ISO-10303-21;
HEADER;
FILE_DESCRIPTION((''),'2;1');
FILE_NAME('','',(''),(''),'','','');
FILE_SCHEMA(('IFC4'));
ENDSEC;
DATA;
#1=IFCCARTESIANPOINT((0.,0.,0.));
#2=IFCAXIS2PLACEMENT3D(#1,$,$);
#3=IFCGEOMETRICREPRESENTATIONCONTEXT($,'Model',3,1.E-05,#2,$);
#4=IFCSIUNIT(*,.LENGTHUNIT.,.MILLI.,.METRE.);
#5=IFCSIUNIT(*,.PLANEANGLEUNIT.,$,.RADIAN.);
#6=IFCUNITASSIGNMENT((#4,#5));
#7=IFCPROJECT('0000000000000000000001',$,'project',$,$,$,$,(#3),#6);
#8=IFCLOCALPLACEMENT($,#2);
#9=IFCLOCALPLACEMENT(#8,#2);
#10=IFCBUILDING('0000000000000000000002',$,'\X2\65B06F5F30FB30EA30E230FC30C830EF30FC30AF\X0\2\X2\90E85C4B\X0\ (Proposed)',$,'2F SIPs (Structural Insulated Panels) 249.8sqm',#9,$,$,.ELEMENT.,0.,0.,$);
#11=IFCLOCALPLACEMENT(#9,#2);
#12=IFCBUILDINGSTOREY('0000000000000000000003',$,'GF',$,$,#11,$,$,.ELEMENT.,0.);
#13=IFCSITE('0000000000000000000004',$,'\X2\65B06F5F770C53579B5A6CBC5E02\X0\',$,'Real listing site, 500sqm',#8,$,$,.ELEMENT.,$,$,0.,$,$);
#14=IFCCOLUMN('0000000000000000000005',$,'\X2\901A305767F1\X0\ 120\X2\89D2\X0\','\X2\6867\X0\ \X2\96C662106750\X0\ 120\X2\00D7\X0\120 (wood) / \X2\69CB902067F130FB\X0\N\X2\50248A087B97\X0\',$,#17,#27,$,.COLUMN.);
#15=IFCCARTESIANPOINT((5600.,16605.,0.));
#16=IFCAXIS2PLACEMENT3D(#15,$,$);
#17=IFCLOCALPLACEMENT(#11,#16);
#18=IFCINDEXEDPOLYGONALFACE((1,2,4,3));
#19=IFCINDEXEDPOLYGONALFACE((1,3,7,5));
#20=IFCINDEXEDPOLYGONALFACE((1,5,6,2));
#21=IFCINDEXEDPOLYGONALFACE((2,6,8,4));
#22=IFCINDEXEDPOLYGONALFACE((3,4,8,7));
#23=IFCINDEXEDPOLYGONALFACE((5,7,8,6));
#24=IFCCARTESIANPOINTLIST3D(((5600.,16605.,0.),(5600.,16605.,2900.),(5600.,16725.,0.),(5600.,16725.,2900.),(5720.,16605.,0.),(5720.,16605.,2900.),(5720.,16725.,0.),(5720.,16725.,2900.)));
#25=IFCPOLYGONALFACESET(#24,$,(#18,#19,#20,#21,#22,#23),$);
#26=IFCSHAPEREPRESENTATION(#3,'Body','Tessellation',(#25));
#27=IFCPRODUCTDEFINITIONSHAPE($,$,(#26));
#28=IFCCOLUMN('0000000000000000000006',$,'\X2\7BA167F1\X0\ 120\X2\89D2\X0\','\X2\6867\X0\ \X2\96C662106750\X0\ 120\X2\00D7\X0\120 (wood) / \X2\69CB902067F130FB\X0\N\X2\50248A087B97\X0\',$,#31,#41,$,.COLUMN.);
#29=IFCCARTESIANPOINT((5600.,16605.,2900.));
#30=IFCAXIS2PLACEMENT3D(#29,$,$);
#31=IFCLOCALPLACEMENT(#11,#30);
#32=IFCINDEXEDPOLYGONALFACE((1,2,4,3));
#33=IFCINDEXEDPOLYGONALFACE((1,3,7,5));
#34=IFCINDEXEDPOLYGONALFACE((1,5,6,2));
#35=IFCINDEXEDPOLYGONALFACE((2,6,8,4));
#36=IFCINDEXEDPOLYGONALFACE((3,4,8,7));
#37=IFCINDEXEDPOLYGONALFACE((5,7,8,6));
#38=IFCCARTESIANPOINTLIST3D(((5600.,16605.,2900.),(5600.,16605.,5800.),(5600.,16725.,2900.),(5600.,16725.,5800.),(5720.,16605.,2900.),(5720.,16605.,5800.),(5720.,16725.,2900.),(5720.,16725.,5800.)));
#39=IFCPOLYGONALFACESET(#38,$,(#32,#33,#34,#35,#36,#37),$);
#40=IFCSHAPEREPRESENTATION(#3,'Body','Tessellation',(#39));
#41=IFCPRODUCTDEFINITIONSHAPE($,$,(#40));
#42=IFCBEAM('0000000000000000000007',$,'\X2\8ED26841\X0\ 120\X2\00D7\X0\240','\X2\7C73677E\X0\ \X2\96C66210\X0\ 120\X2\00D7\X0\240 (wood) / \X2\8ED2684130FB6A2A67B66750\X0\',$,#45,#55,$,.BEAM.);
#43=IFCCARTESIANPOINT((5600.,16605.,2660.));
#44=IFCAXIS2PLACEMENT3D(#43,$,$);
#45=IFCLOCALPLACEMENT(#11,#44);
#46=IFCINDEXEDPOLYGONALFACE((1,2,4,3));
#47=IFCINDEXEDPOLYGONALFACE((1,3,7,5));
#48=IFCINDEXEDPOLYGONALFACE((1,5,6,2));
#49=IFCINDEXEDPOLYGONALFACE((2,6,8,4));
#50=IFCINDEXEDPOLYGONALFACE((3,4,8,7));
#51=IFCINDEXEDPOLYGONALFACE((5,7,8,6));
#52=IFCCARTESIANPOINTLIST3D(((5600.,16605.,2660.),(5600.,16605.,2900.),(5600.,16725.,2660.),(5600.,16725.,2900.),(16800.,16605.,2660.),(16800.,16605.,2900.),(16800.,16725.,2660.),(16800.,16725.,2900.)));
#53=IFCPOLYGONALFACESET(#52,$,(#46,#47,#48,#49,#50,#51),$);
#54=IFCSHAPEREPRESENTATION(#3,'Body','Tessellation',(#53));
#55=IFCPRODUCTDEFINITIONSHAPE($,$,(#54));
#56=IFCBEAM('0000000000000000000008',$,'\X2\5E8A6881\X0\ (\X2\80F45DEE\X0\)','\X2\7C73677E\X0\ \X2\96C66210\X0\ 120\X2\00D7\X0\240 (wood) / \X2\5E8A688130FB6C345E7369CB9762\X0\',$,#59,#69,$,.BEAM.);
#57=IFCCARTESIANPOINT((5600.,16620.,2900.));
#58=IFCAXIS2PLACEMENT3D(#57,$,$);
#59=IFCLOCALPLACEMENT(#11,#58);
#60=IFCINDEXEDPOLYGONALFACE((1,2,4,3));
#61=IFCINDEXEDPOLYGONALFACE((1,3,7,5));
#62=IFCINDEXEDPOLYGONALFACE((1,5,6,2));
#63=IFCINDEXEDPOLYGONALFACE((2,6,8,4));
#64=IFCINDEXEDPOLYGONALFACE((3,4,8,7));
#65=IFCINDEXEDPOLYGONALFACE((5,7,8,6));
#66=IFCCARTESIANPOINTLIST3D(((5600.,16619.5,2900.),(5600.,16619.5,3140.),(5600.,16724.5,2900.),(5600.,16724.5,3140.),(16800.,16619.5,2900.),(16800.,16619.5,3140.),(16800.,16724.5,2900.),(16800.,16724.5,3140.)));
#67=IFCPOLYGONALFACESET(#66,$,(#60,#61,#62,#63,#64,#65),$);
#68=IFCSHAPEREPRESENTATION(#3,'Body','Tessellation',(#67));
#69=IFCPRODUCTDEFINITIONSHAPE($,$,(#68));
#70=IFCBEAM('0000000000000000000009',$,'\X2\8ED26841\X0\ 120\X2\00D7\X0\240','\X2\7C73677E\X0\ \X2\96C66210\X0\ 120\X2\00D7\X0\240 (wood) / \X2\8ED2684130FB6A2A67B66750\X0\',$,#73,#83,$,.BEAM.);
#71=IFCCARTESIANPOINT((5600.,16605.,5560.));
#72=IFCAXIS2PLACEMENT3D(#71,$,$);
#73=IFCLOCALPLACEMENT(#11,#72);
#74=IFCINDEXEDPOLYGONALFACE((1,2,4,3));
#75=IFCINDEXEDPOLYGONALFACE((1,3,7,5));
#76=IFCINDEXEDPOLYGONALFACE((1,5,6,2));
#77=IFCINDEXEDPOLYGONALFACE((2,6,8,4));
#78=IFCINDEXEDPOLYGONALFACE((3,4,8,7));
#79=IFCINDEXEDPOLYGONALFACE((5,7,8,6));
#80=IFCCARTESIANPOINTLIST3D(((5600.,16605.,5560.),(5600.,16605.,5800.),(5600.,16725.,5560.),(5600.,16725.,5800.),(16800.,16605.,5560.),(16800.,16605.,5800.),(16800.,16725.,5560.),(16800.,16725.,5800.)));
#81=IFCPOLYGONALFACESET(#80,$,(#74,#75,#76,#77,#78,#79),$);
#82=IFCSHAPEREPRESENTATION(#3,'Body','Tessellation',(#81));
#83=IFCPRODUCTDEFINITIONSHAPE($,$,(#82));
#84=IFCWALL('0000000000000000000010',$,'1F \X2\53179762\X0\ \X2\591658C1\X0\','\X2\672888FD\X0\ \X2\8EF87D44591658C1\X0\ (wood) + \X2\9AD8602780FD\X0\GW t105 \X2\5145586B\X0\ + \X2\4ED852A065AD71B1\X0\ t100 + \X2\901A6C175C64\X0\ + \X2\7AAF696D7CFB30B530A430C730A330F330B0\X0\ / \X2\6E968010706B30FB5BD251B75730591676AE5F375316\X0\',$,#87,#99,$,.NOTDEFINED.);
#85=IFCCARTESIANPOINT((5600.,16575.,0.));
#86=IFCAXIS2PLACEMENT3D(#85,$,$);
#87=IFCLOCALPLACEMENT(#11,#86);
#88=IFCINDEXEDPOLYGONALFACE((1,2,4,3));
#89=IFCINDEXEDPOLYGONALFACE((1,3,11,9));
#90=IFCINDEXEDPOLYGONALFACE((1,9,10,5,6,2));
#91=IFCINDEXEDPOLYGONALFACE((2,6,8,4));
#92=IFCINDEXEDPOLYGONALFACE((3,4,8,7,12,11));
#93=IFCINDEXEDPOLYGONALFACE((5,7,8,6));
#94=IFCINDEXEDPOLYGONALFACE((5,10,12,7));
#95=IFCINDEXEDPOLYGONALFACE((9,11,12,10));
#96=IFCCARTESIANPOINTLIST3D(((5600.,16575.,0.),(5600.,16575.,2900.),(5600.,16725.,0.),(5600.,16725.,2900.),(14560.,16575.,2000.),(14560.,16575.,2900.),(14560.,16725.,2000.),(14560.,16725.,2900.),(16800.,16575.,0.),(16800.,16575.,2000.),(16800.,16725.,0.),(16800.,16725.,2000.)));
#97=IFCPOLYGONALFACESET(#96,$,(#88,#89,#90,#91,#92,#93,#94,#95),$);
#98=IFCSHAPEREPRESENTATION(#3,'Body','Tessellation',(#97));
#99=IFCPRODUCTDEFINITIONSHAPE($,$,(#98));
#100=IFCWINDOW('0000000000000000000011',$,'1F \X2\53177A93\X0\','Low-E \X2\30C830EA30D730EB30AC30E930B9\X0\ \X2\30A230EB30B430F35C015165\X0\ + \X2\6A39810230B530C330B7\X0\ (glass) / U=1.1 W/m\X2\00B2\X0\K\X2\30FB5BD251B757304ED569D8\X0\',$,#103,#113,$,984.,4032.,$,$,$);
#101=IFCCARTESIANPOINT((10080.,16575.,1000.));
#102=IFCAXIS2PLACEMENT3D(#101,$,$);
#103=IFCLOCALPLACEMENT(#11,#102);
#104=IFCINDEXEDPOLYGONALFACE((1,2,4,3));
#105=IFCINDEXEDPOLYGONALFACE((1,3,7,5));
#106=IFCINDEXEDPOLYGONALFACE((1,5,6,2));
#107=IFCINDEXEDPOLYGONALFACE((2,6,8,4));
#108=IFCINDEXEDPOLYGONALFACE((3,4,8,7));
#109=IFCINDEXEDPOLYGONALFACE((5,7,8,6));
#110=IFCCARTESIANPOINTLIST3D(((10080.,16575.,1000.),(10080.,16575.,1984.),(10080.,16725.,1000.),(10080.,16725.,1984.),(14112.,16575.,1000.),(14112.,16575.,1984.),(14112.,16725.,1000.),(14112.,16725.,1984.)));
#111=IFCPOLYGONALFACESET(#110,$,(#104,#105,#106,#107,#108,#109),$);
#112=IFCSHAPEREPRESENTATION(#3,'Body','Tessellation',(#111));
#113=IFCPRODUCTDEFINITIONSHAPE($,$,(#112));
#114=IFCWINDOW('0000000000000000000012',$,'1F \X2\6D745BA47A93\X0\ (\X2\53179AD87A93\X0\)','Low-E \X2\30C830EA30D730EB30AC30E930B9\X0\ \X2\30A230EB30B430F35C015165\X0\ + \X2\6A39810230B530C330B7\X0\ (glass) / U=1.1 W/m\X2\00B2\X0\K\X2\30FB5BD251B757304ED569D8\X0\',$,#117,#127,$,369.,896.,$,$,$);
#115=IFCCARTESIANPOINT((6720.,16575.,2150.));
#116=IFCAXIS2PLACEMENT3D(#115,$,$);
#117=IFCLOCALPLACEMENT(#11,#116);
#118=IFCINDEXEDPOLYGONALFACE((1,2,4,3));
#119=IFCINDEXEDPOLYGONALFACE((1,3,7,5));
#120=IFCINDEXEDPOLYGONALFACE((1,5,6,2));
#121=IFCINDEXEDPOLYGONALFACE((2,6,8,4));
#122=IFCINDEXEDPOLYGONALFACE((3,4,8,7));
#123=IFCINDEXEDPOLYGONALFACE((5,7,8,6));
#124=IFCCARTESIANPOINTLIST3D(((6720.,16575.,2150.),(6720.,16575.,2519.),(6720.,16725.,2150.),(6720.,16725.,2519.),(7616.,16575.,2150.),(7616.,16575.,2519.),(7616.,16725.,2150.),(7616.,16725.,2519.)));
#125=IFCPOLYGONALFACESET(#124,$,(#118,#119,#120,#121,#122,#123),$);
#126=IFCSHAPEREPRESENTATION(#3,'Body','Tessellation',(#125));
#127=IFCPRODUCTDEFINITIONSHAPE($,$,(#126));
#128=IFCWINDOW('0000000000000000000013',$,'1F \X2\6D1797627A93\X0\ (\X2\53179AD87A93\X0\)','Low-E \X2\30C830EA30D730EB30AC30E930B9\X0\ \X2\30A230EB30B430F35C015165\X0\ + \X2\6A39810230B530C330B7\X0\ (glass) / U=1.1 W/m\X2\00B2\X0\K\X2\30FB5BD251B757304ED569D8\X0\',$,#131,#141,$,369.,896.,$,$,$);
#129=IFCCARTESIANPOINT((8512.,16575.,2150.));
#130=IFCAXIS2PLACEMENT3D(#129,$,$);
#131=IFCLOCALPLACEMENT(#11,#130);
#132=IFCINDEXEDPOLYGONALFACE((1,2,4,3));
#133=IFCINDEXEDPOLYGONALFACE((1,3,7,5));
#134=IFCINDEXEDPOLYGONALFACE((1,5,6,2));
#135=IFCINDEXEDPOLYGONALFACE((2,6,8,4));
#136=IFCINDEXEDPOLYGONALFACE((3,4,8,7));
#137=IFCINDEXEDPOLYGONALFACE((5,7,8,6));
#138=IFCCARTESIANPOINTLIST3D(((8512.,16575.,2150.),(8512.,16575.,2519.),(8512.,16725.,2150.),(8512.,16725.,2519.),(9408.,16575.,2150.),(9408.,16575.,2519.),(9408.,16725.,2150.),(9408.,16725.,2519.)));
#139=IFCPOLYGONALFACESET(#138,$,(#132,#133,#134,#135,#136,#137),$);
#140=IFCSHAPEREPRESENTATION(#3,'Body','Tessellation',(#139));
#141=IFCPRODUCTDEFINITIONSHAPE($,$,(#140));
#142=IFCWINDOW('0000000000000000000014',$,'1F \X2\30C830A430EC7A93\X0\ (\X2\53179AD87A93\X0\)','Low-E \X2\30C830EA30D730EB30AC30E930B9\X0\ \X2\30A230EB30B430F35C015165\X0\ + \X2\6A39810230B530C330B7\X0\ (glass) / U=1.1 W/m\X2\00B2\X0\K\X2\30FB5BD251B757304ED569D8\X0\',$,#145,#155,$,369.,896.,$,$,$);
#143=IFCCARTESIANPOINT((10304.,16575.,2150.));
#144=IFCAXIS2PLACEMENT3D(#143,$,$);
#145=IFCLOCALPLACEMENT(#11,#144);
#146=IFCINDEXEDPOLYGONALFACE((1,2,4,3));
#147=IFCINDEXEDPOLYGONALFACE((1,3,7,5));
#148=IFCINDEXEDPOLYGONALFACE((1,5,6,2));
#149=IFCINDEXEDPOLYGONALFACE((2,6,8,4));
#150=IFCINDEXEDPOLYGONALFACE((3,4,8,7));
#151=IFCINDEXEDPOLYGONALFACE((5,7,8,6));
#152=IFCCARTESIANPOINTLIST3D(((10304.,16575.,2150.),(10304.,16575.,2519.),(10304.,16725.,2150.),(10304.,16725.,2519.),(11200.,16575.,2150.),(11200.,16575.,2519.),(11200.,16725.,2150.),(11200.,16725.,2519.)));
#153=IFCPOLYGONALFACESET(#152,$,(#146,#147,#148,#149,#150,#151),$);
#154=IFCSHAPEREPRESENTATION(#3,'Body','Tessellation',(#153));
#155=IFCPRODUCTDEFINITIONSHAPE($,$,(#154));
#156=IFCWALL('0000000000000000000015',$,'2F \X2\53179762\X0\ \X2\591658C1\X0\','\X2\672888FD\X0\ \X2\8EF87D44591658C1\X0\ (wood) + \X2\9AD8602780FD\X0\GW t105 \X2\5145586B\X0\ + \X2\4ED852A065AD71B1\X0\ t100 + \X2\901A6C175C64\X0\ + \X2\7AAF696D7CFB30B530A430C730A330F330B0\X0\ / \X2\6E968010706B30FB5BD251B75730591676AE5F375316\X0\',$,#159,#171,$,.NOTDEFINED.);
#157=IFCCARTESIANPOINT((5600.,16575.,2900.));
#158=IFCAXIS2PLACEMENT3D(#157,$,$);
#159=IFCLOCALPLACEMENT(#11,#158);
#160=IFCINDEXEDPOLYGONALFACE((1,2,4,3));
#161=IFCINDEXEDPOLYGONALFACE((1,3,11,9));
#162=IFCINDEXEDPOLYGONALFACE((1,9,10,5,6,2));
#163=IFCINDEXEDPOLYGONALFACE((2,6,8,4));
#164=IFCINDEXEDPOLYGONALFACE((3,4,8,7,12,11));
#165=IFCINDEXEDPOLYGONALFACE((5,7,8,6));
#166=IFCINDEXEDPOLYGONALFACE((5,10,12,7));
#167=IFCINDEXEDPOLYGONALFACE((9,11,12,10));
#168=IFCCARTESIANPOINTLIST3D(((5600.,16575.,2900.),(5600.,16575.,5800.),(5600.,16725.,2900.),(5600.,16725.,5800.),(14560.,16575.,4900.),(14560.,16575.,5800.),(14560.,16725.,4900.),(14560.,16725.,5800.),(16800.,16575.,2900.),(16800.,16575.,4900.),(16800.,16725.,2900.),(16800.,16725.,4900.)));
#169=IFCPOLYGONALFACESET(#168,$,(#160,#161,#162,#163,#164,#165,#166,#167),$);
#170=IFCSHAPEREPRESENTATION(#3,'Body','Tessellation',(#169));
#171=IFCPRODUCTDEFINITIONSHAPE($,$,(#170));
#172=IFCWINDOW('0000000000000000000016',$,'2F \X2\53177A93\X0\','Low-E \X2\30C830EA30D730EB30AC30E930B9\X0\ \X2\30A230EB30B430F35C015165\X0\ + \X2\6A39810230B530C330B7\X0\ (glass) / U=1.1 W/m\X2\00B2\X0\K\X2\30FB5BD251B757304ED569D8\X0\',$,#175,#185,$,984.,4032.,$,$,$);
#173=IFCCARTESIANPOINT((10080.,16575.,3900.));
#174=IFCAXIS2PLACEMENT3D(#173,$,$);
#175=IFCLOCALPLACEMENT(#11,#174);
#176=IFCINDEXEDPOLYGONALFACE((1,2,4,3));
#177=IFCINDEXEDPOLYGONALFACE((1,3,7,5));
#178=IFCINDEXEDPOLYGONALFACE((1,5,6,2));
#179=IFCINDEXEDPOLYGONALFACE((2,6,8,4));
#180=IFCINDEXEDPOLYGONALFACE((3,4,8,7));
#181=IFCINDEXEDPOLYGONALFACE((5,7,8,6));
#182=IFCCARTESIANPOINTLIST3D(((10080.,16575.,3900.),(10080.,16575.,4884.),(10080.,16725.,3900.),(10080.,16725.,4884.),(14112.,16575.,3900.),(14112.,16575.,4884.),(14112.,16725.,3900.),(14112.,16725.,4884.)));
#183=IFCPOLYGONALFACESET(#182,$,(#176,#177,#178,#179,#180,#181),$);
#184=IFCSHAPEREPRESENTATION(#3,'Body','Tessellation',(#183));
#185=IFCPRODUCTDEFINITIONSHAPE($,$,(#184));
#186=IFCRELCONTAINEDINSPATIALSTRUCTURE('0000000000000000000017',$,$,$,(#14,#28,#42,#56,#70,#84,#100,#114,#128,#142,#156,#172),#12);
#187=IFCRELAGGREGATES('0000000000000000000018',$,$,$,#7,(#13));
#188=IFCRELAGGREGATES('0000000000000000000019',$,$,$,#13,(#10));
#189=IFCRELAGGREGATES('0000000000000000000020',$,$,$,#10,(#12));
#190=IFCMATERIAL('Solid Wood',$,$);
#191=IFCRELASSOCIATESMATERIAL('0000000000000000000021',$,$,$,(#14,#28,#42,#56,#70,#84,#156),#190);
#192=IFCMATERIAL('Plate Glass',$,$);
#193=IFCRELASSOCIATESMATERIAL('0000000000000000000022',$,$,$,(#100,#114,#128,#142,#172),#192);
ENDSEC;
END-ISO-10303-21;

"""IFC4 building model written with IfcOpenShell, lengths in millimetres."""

from ifc_helpers import new_model, si_unit, frame, frame_2d, origin, place, context, project, spatial, rectangle, extrude, material, element, fill, save


model = new_model("IFC4")

# Units and contexts
model_context = context("Model", 3, precision=1e-05, world=origin())
ifc_project = project(units=[si_unit("LENGTHUNIT", "METRE", prefix="MILLI"), si_unit("PLANEANGLEUNIT", "RADIAN")], contexts=[model_context])

# Site, building, storey
site_placement = place(None, origin())
site = spatial("IfcSite", under=ifc_project, at=site_placement, Name="新潟県南魚沼市", ObjectType="Real listing site, 500sqm", CompositionType="ELEMENT", RefElevation=0.0)
building_placement = place(site_placement, origin())
building = spatial("IfcBuilding", under=site, at=building_placement, Name="新潟・リモートワーク2部屋 (Proposed)", ObjectType="2F SIPs (Structural Insulated Panels) 249.8sqm", CompositionType="ELEMENT", ElevationOfRefHeight=0.0, ElevationOfTerrain=0.0)
storey_placement = place(building_placement, origin())
storey = spatial("IfcBuildingStorey", under=building, at=storey_placement, Name="GF", CompositionType="ELEMENT", Elevation=0.0)

# Columns
ifc_material_1 = material(Name="Solid Wood")
column_1_placement = place(storey_placement, frame((5600.0, 16605.0, 0.0)))
element("IfcColumn", 1, at=column_1_placement, inside=storey, material=ifc_material_1, Name="通し柱 120角", Description="桧 集成材 120×120 (wood) / 構造柱・N値計算", PredefinedType="COLUMN", context=model_context, shape_type="SweptSolid", body=[
    extrude(rectangle(XDim=120.0, YDim=120.0, at=frame_2d((60.0, 60.0))), frame((5600.0, 16605.0, 0.0)), (0.0, 0.0, 1.0), 2900.0),
])
column_2_placement = place(storey_placement, frame((5600.0, 16605.0, 2900.0)))
element("IfcColumn", 2, at=column_2_placement, inside=storey, material=ifc_material_1, Name="管柱 120角", Description="桧 集成材 120×120 (wood) / 構造柱・N値計算", PredefinedType="COLUMN", context=model_context, shape_type="SweptSolid", body=[
    extrude(rectangle(XDim=120.0, YDim=120.0, at=frame_2d((60.0, 60.0))), frame((5600.0, 16605.0, 2900.0)), (0.0, 0.0, 1.0), 2900.0),
])

# Beams
beam_1_placement = place(storey_placement, frame((5600.0, 16605.0, 2660.0)))
element("IfcBeam", 3, at=beam_1_placement, inside=storey, material=ifc_material_1, Name="軒桁 120×240", Description="米松 集成 120×240 (wood) / 軒桁・横架材", PredefinedType="BEAM", context=model_context, shape_type="SweptSolid", body=[
    extrude(rectangle(XDim=11200.0, YDim=120.0, at=frame_2d((5600.0, 60.0))), frame((5600.0, 16605.0, 2660.0)), (0.0, 0.0, 1.0), 240.0),
])
beam_2_placement = place(storey_placement, frame((5600.0, 16620.0, 2900.0)))
element("IfcBeam", 4, at=beam_2_placement, inside=storey, material=ifc_material_1, Name="床梁 (胴差)", Description="米松 集成 120×240 (wood) / 床梁・水平構面", PredefinedType="BEAM", context=model_context, shape_type="SweptSolid", body=[
    extrude(rectangle(XDim=11200.0, YDim=105.0, at=frame_2d((5600.0, 52.0))), frame((5600.0, 16620.0, 2900.0)), (0.0, 0.0, 1.0), 240.0),
])
beam_3_placement = place(storey_placement, frame((5600.0, 16605.0, 5560.0)))
element("IfcBeam", 5, at=beam_3_placement, inside=storey, material=ifc_material_1, Name="軒桁 120×240", Description="米松 集成 120×240 (wood) / 軒桁・横架材", PredefinedType="BEAM", context=model_context, shape_type="SweptSolid", body=[
    extrude(rectangle(XDim=11200.0, YDim=120.0, at=frame_2d((5600.0, 60.0))), frame((5600.0, 16605.0, 5560.0)), (0.0, 0.0, 1.0), 240.0),
])

# Wall, openings, windows
wall_1_placement = place(storey_placement, frame((5600.0, 16575.0, 0.0)))
wall_1 = element("IfcWall", 6, at=wall_1_placement, inside=storey, material=ifc_material_1, Name="1F 北面 外壁", Description="木製 軸組外壁 (wood) + 高性能GW t105 充填 + 付加断熱 t100 + 通気層 + 窯業系サイディング / 準耐火・寒冷地外皮強化", PredefinedType="NOTDEFINED", context=model_context, shape_type="SweptSolid", body=[
    extrude(rectangle(XDim=11200.0, YDim=150.0, at=frame_2d((5600.0, 75.0))), frame((5600.0, 16575.0, 0.0)), (0.0, 0.0, 1.0), 2900.0),
])
opening_1_placement = place(storey_placement, frame((10080.0, 16575.0, 1000.0)))
opening_1 = element("IfcOpeningElement", 7, at=opening_1_placement, cuts=wall_1, PredefinedType="NOTDEFINED", context=model_context, shape_type="SweptSolid", body=[
    extrude(rectangle(XDim=4032.0, YDim=150.0, at=frame_2d((2016.0, 75.0))), frame((10080.0, 16575.0, 1000.0)), (0.0, 0.0, 1.0), 984.0),
])
opening_2_placement = place(storey_placement, frame((6720.0, 16575.0, 2150.0)))
opening_2 = element("IfcOpeningElement", 8, at=opening_2_placement, cuts=wall_1, PredefinedType="NOTDEFINED", context=model_context, shape_type="SweptSolid", body=[
    extrude(rectangle(XDim=896.0, YDim=150.0, at=frame_2d((448.0, 75.0))), frame((6720.0, 16575.0, 2150.0)), (0.0, 0.0, 1.0), 369.0),
])
opening_3_placement = place(storey_placement, frame((8512.0, 16575.0, 2150.0)))
opening_3 = element("IfcOpeningElement", 9, at=opening_3_placement, cuts=wall_1, PredefinedType="NOTDEFINED", context=model_context, shape_type="SweptSolid", body=[
    extrude(rectangle(XDim=896.0, YDim=150.0, at=frame_2d((448.0, 75.0))), frame((8512.0, 16575.0, 2150.0)), (0.0, 0.0, 1.0), 369.0),
])
opening_4_placement = place(storey_placement, frame((10304.0, 16575.0, 2150.0)))
opening_4 = element("IfcOpeningElement", 10, at=opening_4_placement, cuts=wall_1, PredefinedType="NOTDEFINED", context=model_context, shape_type="SweptSolid", body=[
    extrude(rectangle(XDim=896.0, YDim=150.0, at=frame_2d((448.0, 75.0))), frame((10304.0, 16575.0, 2150.0)), (0.0, 0.0, 1.0), 369.0),
])
ifc_material_2 = material(Name="Plate Glass")
window_1_placement = place(storey_placement, frame((10080.0, 16575.0, 1000.0)))
window_1 = element("IfcWindow", 11, at=window_1_placement, inside=storey, material=ifc_material_2, Name="1F 北窓", Description="Low-E トリプルガラス アルゴン封入 + 樹脂サッシ (glass) / U=1.1 W/m²K・寒冷地仕様", OverallHeight=984.0, OverallWidth=4032.0, context=model_context, shape_type="SweptSolid", body=[
    extrude(rectangle(XDim=4032.0, YDim=150.0, at=frame_2d((2016.0, 75.0))), frame((10080.0, 16575.0, 1000.0)), (0.0, 0.0, 1.0), 984.0),
])
fill(opening_1, window_1)
window_2_placement = place(storey_placement, frame((6720.0, 16575.0, 2150.0)))
window_2 = element("IfcWindow", 12, at=window_2_placement, inside=storey, material=ifc_material_2, Name="1F 浴室窓 (北高窓)", Description="Low-E トリプルガラス アルゴン封入 + 樹脂サッシ (glass) / U=1.1 W/m²K・寒冷地仕様", OverallHeight=369.0, OverallWidth=896.0, context=model_context, shape_type="SweptSolid", body=[
    extrude(rectangle(XDim=896.0, YDim=150.0, at=frame_2d((448.0, 75.0))), frame((6720.0, 16575.0, 2150.0)), (0.0, 0.0, 1.0), 369.0),
])
fill(opening_2, window_2)
window_3_placement = place(storey_placement, frame((8512.0, 16575.0, 2150.0)))
window_3 = element("IfcWindow", 13, at=window_3_placement, inside=storey, material=ifc_material_2, Name="1F 洗面窓 (北高窓)", Description="Low-E トリプルガラス アルゴン封入 + 樹脂サッシ (glass) / U=1.1 W/m²K・寒冷地仕様", OverallHeight=369.0, OverallWidth=896.0, context=model_context, shape_type="SweptSolid", body=[
    extrude(rectangle(XDim=896.0, YDim=150.0, at=frame_2d((448.0, 75.0))), frame((8512.0, 16575.0, 2150.0)), (0.0, 0.0, 1.0), 369.0),
])
fill(opening_3, window_3)
window_4_placement = place(storey_placement, frame((10304.0, 16575.0, 2150.0)))
window_4 = element("IfcWindow", 14, at=window_4_placement, inside=storey, material=ifc_material_2, Name="1F トイレ窓 (北高窓)", Description="Low-E トリプルガラス アルゴン封入 + 樹脂サッシ (glass) / U=1.1 W/m²K・寒冷地仕様", OverallHeight=369.0, OverallWidth=896.0, context=model_context, shape_type="SweptSolid", body=[
    extrude(rectangle(XDim=896.0, YDim=150.0, at=frame_2d((448.0, 75.0))), frame((10304.0, 16575.0, 2150.0)), (0.0, 0.0, 1.0), 369.0),
])
fill(opening_4, window_4)

# Wall, opening, window
wall_2_placement = place(storey_placement, frame((5600.0, 16575.0, 2900.0)))
wall_2 = element("IfcWall", 15, at=wall_2_placement, inside=storey, material=ifc_material_1, Name="2F 北面 外壁", Description="木製 軸組外壁 (wood) + 高性能GW t105 充填 + 付加断熱 t100 + 通気層 + 窯業系サイディング / 準耐火・寒冷地外皮強化", PredefinedType="NOTDEFINED", context=model_context, shape_type="SweptSolid", body=[
    extrude(rectangle(XDim=11200.0, YDim=150.0, at=frame_2d((5600.0, 75.0))), frame((5600.0, 16575.0, 2900.0)), (0.0, 0.0, 1.0), 2900.0),
])
opening_5_placement = place(storey_placement, frame((10080.0, 16575.0, 3900.0)))
opening_5 = element("IfcOpeningElement", 16, at=opening_5_placement, cuts=wall_2, PredefinedType="NOTDEFINED", context=model_context, shape_type="SweptSolid", body=[
    extrude(rectangle(XDim=4032.0, YDim=150.0, at=frame_2d((2016.0, 75.0))), frame((10080.0, 16575.0, 3900.0)), (0.0, 0.0, 1.0), 984.0),
])
window_5_placement = place(storey_placement, frame((10080.0, 16575.0, 3900.0)))
window_5 = element("IfcWindow", 17, at=window_5_placement, inside=storey, material=ifc_material_2, Name="2F 北窓", Description="Low-E トリプルガラス アルゴン封入 + 樹脂サッシ (glass) / U=1.1 W/m²K・寒冷地仕様", OverallHeight=984.0, OverallWidth=4032.0, context=model_context, shape_type="SweptSolid", body=[
    extrude(rectangle(XDim=4032.0, YDim=150.0, at=frame_2d((2016.0, 75.0))), frame((10080.0, 16575.0, 3900.0)), (0.0, 0.0, 1.0), 984.0),
])
fill(opening_5, window_5)

save(model, "model.ifc")
